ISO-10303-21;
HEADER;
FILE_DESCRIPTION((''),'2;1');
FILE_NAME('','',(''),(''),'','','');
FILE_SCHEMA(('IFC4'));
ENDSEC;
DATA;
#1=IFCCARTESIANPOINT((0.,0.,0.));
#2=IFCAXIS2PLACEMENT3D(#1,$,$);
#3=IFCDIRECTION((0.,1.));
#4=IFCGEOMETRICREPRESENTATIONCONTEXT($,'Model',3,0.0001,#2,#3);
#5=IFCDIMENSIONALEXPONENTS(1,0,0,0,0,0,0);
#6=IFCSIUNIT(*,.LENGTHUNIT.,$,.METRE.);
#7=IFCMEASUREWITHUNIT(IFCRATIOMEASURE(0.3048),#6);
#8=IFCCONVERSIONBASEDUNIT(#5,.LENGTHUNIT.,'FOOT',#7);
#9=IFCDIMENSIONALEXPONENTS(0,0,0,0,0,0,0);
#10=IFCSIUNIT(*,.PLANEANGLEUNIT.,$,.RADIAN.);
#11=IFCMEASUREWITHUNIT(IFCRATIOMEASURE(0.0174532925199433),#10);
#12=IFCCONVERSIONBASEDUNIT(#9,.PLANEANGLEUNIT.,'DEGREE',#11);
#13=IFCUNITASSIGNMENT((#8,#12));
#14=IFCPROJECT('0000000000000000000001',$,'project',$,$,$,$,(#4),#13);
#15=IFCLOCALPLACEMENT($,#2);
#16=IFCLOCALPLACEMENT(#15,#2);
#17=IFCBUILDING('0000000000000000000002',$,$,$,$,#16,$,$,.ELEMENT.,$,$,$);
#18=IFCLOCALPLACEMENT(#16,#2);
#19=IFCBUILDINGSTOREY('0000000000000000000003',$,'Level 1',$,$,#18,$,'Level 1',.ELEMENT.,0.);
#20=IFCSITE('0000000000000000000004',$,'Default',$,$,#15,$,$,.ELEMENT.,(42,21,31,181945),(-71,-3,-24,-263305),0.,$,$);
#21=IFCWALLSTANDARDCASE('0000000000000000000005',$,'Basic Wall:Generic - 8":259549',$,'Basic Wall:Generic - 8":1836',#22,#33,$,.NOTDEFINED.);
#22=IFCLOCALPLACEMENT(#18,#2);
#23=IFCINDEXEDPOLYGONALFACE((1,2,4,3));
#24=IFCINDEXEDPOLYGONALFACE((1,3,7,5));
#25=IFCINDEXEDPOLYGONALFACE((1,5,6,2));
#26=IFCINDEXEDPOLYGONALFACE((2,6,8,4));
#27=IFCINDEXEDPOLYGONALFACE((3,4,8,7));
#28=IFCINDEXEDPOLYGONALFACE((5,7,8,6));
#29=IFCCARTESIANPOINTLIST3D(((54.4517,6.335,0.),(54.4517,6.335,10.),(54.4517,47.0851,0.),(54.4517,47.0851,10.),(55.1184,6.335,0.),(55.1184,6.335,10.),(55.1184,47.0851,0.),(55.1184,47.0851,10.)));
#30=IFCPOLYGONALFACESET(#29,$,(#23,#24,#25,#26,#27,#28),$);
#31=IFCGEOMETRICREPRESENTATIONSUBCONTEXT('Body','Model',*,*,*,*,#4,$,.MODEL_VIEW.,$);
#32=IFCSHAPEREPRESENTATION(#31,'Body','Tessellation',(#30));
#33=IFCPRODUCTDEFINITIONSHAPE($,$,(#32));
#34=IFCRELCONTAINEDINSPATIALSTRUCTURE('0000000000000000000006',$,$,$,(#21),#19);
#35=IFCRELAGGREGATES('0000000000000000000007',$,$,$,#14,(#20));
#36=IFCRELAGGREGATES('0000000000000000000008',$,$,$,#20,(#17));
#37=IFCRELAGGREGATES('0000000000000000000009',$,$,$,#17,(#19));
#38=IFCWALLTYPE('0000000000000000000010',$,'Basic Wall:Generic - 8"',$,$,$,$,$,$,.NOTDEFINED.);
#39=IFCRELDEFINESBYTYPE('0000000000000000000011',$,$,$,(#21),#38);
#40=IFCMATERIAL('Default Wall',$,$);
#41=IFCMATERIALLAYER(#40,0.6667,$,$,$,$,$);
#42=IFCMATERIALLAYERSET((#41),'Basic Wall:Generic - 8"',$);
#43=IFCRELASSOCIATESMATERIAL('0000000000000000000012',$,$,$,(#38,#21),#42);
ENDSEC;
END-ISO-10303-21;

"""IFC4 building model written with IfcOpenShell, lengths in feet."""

from ifc_helpers import new_model, entity, si_unit, converted_unit, direction, frame, frame_2d, origin, place, context, subcontext, project, spatial, rectangle, extrude, material, layer, layer_set, layer_usage, type_object, element, save


model = new_model("IFC4")

# Units and contexts
model_context = context("Model", 3, precision=0.0001, world=origin(), true_north=direction((0.0, 1.0)))
body_context = subcontext(model_context, "Body", "Model", "MODEL_VIEW")
ifc_project = project(units=[converted_unit("LENGTHUNIT", "FOOT", entity("IfcRatioMeasure", 0.3048), si_unit("LENGTHUNIT", "METRE"), dimensions=[1, 0, 0, 0, 0, 0, 0]), converted_unit("PLANEANGLEUNIT", "DEGREE", entity("IfcRatioMeasure", 0.0174532925199433), si_unit("PLANEANGLEUNIT", "RADIAN"), dimensions=[0, 0, 0, 0, 0, 0, 0])], contexts=[model_context])

# Site, building, storey
site_placement = place(None, origin())
site = spatial("IfcSite", under=ifc_project, at=site_placement, Name="Default", CompositionType="ELEMENT", RefLatitude=(42, 21, 31, 181945), RefLongitude=(-71, -3, -24, -263305), RefElevation=0.0)
building_placement = place(site_placement, origin())
building = spatial("IfcBuilding", under=site, at=building_placement, CompositionType="ELEMENT")
storey_placement = place(building_placement, origin())
storey = spatial("IfcBuildingStorey", under=building, at=storey_placement, Name="Level 1", LongName="Level 1", CompositionType="ELEMENT", Elevation=0.0)

# Wall
ifc_material_1 = material(Name="Default Wall")
ifc_layer = layer(ifc_material_1, 0.6667)
ifc_layer_set = layer_set([ifc_layer], Name="Basic Wall:Generic - 8\"")
ifc_layer_usage = layer_usage(ifc_layer_set, "AXIS2", "NEGATIVE", 0.3333)
wall_type = type_object("IfcWallType", Name="Basic Wall:Generic - 8\"", PredefinedType="NOTDEFINED", material=ifc_layer_set)
wall_placement = place(storey_placement, frame((54.785, 47.0851, 0.0), z_axis=(0.0, 0.0, 1.0), x_axis=(0.0, -1.0, 0.0)))
element("IfcWallStandardCase", 1, at=wall_placement, inside=storey, type_object=wall_type, material=ifc_layer_usage, Name="Basic Wall:Generic - 8\":259549", ObjectType="Basic Wall:Generic - 8\":1836", PredefinedType="NOTDEFINED", context=body_context, shape_type="SweptSolid", body=[
    extrude(rectangle(XDim=40.7501, YDim=0.6667, at=frame_2d((20.375, 0.0), x_axis=(-1.0, 0.0))), origin(), (0.0, 0.0, 1.0), 10.0),
])

save(model, "model.ifc")
